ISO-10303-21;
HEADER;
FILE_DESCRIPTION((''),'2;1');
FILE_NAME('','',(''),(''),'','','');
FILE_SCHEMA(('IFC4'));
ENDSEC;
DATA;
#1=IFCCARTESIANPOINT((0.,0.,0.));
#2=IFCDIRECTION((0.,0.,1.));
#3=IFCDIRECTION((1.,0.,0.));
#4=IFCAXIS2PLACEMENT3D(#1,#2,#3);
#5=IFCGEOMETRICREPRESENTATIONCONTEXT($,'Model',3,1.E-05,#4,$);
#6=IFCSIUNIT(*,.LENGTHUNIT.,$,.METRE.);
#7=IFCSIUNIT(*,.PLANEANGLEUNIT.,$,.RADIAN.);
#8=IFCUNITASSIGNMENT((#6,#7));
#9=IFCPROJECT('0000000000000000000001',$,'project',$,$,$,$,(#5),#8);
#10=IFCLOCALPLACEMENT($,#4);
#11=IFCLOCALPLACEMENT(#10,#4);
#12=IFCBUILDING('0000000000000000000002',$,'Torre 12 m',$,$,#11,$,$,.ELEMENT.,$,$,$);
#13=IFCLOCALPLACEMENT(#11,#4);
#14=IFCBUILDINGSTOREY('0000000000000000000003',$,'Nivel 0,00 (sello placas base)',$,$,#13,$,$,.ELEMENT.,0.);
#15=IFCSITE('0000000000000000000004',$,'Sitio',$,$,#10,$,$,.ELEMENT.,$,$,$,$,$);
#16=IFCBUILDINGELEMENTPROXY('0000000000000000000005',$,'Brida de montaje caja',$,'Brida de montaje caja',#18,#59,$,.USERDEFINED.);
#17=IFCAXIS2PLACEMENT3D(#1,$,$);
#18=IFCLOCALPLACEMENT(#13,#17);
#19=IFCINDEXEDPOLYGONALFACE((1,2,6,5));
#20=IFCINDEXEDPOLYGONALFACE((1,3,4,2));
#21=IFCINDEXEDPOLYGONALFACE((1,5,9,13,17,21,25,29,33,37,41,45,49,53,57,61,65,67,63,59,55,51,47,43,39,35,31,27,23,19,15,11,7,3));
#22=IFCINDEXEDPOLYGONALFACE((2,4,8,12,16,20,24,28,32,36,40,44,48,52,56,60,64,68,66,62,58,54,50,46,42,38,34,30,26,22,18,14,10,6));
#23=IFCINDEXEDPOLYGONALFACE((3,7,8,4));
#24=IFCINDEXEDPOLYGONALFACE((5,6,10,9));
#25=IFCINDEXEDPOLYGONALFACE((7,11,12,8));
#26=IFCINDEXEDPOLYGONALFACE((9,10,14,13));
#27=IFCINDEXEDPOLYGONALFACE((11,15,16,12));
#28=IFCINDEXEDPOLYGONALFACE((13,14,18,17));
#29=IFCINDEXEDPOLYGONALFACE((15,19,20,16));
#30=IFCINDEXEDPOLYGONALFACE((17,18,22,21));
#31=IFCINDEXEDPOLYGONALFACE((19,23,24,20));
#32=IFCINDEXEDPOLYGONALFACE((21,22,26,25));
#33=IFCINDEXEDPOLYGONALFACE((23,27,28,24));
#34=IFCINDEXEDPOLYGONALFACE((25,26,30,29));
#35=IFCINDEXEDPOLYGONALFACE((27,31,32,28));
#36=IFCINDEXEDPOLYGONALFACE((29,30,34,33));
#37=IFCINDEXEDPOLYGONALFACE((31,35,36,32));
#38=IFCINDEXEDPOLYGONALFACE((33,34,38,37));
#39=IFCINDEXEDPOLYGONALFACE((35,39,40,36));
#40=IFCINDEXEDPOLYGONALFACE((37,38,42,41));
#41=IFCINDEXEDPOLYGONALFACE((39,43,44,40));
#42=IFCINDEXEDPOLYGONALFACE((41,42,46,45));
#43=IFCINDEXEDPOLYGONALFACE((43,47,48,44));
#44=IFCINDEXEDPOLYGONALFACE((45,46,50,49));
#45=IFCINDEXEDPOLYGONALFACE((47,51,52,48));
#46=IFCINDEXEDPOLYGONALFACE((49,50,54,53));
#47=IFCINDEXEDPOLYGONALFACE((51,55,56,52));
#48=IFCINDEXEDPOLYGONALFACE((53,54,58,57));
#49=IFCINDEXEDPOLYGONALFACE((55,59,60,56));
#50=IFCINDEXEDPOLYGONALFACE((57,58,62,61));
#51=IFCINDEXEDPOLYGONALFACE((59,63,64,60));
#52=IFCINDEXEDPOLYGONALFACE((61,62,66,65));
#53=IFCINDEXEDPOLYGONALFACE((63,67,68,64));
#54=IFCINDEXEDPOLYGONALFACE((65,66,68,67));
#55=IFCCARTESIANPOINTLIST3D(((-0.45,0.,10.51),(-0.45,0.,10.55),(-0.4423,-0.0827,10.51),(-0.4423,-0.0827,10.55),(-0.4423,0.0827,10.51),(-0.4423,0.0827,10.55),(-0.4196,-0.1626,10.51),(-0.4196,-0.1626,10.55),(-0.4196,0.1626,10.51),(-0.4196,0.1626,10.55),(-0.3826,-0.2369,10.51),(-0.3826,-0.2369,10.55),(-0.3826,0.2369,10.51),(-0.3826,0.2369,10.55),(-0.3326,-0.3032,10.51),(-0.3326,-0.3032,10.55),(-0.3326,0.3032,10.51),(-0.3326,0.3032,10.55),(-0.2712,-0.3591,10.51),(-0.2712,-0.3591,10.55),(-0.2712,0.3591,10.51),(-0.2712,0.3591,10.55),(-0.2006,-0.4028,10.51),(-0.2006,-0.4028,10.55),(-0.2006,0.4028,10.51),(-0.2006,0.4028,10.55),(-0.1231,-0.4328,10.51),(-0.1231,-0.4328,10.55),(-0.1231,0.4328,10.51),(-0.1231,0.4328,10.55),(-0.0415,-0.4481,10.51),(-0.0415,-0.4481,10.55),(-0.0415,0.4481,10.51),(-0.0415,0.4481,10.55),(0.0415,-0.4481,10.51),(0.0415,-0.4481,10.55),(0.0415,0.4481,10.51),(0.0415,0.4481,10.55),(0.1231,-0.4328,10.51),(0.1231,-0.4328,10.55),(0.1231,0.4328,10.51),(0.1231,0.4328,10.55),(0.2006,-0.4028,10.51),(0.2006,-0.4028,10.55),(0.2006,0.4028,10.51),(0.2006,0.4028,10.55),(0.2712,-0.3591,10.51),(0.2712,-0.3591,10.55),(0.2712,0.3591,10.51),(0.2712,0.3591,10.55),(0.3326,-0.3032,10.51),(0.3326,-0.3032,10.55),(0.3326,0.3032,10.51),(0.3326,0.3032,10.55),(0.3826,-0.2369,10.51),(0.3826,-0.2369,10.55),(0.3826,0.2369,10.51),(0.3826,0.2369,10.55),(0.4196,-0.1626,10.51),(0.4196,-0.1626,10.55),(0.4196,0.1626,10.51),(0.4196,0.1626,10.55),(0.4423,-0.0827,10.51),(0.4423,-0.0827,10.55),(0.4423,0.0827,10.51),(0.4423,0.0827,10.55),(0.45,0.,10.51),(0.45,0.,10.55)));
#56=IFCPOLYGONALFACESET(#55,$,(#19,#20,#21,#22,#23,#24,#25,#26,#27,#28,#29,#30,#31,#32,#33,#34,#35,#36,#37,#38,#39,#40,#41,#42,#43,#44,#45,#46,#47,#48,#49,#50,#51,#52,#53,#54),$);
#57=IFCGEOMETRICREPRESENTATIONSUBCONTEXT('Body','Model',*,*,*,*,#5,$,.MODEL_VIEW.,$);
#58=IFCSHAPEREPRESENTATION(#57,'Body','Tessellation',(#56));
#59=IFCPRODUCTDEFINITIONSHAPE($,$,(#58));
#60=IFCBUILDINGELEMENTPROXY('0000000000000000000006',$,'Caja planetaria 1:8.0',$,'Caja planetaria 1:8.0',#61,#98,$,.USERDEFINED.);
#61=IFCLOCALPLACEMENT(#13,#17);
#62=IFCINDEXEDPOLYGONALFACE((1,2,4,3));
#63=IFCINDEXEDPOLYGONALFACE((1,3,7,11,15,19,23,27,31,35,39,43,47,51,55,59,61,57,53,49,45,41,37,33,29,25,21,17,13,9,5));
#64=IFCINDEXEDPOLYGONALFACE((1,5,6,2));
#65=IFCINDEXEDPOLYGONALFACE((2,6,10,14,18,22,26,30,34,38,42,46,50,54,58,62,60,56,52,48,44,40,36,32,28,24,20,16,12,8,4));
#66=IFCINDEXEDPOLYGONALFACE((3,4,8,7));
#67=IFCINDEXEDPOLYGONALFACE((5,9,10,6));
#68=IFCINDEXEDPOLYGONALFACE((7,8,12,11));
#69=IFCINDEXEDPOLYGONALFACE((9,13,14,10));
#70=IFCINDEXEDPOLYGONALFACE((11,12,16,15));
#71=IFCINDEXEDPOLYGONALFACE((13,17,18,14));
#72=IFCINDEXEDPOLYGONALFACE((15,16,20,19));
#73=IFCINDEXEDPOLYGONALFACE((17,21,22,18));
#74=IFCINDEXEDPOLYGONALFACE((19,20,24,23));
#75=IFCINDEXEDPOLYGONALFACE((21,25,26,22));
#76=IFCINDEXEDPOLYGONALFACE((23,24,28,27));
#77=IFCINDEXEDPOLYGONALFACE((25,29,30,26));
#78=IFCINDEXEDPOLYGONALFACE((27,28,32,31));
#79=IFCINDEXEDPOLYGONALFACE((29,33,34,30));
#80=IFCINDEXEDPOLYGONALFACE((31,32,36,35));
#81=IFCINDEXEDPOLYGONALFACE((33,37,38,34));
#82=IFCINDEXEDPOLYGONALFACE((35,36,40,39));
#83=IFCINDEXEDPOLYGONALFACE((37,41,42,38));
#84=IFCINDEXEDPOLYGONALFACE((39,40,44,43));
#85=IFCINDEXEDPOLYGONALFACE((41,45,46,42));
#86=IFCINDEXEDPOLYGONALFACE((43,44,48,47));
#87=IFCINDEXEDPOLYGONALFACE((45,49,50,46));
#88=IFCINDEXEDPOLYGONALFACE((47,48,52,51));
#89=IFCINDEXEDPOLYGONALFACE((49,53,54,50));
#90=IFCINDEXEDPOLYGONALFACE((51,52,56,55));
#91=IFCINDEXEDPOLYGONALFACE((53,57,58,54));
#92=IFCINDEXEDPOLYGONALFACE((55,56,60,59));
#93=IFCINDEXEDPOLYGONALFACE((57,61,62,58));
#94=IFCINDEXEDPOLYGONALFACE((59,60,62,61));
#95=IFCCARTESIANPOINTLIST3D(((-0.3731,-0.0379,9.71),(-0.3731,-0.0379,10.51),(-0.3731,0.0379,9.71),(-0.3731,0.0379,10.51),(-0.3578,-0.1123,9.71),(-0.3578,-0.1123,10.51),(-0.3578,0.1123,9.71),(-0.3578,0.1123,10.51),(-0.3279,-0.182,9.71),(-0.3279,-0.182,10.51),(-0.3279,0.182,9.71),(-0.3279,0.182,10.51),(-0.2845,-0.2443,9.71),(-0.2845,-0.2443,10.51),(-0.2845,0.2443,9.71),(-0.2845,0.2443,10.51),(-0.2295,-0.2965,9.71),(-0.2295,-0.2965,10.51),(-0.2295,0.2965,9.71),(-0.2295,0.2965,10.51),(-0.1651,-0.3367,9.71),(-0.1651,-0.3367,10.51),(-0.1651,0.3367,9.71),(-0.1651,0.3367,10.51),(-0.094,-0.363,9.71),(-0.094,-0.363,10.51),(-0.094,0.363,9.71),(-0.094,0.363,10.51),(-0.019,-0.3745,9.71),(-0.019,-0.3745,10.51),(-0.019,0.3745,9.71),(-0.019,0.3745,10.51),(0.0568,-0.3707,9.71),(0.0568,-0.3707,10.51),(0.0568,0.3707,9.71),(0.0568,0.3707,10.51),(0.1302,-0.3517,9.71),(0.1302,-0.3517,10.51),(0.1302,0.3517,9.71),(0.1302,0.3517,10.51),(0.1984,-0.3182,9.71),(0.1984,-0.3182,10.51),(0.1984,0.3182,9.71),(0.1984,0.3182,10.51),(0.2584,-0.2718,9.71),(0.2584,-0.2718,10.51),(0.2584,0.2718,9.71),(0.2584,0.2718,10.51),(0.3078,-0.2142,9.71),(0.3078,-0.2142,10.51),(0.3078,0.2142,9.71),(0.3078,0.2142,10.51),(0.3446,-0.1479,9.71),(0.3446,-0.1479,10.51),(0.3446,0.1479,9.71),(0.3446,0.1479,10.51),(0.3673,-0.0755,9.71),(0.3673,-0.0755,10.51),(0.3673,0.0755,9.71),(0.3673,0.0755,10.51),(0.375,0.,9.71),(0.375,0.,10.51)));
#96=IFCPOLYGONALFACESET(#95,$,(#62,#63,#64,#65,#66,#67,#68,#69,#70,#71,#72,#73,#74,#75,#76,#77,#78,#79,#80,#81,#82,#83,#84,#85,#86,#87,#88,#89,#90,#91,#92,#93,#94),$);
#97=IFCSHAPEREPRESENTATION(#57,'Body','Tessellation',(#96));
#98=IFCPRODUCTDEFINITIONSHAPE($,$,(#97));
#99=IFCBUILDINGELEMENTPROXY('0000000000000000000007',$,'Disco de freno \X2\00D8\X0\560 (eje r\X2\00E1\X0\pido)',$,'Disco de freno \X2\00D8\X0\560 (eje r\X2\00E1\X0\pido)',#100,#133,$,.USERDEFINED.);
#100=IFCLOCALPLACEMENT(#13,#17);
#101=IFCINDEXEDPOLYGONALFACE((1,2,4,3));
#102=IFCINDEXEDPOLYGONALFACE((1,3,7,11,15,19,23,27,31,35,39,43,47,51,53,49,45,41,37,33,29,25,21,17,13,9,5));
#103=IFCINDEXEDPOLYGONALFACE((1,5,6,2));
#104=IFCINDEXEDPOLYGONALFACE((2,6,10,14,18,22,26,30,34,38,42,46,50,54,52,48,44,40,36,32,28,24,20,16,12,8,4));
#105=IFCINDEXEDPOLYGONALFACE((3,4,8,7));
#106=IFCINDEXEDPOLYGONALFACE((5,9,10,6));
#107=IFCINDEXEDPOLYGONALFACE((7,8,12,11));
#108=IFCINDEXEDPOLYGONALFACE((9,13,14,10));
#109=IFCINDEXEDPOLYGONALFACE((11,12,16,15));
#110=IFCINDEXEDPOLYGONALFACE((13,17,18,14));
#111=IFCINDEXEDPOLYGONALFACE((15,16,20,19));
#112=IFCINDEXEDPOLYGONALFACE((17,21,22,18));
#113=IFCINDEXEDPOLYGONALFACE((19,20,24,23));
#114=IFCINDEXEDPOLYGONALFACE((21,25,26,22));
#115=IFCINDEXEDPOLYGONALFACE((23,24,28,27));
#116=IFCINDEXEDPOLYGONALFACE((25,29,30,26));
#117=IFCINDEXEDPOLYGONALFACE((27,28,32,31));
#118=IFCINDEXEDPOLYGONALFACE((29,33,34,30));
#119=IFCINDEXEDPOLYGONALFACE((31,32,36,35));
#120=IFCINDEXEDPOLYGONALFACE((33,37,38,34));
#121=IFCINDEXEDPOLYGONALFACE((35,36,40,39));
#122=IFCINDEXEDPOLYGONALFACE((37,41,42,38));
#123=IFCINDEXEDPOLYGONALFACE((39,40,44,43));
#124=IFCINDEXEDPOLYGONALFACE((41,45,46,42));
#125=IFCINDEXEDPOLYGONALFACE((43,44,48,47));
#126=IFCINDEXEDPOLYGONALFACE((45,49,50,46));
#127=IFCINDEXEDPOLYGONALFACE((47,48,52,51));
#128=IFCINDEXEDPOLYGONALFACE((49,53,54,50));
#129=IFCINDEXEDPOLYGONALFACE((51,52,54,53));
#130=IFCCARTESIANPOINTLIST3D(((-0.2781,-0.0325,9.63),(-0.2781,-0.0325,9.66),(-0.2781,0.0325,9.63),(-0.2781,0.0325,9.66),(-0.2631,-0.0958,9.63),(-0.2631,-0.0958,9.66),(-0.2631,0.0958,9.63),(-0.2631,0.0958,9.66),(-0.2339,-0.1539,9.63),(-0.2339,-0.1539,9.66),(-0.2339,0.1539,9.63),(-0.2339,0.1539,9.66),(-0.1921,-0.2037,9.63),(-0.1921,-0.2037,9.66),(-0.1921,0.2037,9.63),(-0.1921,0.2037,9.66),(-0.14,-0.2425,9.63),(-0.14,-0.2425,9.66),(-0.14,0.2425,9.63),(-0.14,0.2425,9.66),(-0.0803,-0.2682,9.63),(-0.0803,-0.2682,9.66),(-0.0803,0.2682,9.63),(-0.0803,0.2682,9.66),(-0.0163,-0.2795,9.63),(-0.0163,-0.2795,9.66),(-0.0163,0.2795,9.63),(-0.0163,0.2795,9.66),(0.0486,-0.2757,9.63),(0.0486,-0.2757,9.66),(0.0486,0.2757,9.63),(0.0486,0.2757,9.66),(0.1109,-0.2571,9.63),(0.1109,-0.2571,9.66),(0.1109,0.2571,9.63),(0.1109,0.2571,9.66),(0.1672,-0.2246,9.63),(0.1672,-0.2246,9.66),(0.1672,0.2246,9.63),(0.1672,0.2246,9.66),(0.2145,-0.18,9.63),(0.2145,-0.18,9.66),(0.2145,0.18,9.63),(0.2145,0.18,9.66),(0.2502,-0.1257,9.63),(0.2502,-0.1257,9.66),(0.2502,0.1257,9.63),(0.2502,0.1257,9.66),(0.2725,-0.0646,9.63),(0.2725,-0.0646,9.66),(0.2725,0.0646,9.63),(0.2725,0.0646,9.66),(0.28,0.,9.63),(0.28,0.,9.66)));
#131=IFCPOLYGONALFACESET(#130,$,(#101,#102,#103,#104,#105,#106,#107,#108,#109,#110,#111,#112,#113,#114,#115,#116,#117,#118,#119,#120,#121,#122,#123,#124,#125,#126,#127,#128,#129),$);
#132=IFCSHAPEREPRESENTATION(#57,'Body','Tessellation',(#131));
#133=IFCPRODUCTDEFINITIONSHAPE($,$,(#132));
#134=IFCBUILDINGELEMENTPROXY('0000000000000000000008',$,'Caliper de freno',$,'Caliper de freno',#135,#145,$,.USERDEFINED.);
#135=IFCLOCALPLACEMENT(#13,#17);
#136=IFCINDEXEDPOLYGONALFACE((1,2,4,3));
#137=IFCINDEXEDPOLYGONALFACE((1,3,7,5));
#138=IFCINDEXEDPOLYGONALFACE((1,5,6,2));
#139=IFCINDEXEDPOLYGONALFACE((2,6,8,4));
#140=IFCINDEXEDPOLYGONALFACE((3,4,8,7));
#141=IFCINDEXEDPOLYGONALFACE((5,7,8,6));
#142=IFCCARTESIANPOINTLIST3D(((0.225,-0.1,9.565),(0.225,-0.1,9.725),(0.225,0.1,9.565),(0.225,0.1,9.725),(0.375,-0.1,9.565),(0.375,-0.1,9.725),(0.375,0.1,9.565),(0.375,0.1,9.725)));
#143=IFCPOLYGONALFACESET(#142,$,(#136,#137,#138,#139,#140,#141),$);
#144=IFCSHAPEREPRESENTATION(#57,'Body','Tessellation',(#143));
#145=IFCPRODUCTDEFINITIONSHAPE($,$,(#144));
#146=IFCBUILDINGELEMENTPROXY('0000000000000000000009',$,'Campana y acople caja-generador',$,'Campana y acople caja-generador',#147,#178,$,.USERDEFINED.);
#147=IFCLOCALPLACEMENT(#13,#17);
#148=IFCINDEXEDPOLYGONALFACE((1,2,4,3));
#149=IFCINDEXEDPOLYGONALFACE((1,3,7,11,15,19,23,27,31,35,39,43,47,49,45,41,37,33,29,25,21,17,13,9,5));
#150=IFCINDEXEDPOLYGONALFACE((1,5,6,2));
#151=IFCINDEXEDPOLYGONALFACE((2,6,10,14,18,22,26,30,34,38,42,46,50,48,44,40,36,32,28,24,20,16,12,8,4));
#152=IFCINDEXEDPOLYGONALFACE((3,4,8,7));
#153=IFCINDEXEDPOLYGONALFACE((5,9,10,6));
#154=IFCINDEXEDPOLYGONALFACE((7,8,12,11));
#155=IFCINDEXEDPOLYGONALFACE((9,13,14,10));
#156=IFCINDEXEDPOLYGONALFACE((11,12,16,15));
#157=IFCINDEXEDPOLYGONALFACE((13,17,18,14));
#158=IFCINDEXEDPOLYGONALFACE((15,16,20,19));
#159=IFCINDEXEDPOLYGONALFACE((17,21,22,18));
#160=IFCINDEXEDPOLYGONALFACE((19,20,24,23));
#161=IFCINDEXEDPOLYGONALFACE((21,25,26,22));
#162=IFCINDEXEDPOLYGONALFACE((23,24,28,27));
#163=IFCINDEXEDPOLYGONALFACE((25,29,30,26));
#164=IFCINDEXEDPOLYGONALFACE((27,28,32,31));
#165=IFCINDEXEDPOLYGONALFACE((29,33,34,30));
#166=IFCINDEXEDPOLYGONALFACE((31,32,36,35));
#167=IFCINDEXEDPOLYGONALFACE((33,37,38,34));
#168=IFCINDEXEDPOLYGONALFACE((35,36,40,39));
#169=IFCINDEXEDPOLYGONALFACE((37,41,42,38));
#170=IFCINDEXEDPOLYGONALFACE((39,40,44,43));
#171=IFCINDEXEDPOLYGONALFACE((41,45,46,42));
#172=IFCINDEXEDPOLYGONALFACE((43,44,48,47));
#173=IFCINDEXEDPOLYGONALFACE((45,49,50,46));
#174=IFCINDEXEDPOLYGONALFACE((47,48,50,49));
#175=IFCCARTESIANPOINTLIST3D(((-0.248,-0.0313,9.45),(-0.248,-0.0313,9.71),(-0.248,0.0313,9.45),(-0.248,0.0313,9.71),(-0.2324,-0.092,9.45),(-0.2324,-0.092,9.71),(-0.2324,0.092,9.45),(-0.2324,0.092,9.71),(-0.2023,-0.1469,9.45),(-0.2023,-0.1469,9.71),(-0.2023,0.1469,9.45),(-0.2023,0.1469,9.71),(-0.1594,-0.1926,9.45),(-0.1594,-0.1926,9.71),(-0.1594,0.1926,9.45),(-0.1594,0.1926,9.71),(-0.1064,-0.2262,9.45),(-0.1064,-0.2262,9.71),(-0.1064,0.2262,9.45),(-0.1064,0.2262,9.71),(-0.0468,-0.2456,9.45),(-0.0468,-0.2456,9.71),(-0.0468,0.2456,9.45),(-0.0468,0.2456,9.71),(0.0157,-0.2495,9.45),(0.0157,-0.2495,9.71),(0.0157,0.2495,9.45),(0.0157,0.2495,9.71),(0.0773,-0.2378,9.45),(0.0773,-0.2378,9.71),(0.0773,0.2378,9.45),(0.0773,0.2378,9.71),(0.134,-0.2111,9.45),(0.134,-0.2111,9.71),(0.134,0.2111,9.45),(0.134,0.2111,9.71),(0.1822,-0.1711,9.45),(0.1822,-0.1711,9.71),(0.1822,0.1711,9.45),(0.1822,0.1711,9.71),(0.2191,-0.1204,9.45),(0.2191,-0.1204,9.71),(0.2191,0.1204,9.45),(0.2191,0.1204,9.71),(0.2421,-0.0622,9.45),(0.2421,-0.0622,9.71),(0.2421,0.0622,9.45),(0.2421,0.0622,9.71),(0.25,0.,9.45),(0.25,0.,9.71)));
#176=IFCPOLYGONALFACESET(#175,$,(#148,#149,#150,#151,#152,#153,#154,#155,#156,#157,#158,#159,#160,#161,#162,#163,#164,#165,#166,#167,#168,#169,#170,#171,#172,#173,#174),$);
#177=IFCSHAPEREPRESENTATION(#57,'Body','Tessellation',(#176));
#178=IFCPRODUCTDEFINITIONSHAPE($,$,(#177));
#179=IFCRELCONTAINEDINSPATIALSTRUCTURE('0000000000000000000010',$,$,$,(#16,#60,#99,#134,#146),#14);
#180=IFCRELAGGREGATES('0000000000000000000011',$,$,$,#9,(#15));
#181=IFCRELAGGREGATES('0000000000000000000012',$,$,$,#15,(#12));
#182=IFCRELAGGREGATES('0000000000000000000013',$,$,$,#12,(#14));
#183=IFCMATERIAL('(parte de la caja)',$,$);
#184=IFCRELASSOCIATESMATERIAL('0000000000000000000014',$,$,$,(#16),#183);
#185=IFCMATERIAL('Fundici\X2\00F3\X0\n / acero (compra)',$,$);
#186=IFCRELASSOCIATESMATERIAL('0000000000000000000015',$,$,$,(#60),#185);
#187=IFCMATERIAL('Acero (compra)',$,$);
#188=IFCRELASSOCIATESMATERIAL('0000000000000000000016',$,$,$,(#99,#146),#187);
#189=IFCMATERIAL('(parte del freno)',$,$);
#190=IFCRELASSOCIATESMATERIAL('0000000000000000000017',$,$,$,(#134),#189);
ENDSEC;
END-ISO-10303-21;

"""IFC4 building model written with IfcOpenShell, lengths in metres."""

from ifc_helpers import new_model, si_unit, frame, origin, origin_with_axes, origin_2d, place, context, subcontext, project, spatial, rectangle, circle, extrude, material, element, save


model = new_model("IFC4")

# Units and contexts
model_context = context("Model", 3, precision=1e-05, world=origin_with_axes())
body_context = subcontext(model_context, "Body", "Model", "MODEL_VIEW")
ifc_project = project(units=[si_unit("LENGTHUNIT", "METRE"), si_unit("PLANEANGLEUNIT", "RADIAN")], contexts=[model_context])

# Site, building, storey
site_placement = place(None, origin_with_axes())
site = spatial("IfcSite", under=ifc_project, at=site_placement, Name="Sitio", CompositionType="ELEMENT")
building_placement = place(site_placement, origin_with_axes())
building = spatial("IfcBuilding", under=site, at=building_placement, Name="Torre 12 m", CompositionType="ELEMENT")
storey_placement = place(building_placement, origin_with_axes())
storey = spatial("IfcBuildingStorey", under=building, at=storey_placement, Name="Nivel 0,00 (sello placas base)", CompositionType="ELEMENT", Elevation=0.0)

# Building element proxies
ifc_material_1 = material(Name="Acero (compra)")
ifc_material_2 = material(Name="(parte de la caja)")
proxy_1_placement = place(storey_placement, frame((0.0, 0.0, 10.51), z_axis=(0.0, 0.0, 1.0), x_axis=(1.0, 0.0, 0.0)))
element("IfcBuildingElementProxy", 1, at=proxy_1_placement, inside=storey, material=ifc_material_2, Name="Brida de montaje caja", ObjectType="Brida de montaje caja", PredefinedType="USERDEFINED", context=body_context, shape_type="SweptSolid", body=[
    extrude(circle(Radius=0.45, at=origin_2d()), origin(), (0.0, 0.0, 1.0), 0.04),
])
ifc_material_3 = material(Name="Fundición / acero (compra)")
proxy_2_placement = place(storey_placement, frame((0.0, 0.0, 9.71), z_axis=(0.0, 0.0, 1.0), x_axis=(1.0, 0.0, 0.0)))
element("IfcBuildingElementProxy", 2, at=proxy_2_placement, inside=storey, material=ifc_material_3, Name="Caja planetaria 1:8.0", ObjectType="Caja planetaria 1:8.0", PredefinedType="USERDEFINED", context=body_context, shape_type="SweptSolid", body=[
    extrude(circle(Radius=0.375, at=origin_2d()), origin(), (0.0, 0.0, 1.0), 0.8),
])
proxy_3_placement = place(storey_placement, frame((0.0, 0.0, 9.63), z_axis=(0.0, 0.0, 1.0), x_axis=(1.0, 0.0, 0.0)))
element("IfcBuildingElementProxy", 3, at=proxy_3_placement, inside=storey, material=ifc_material_1, Name="Disco de freno Ø560 (eje rápido)", ObjectType="Disco de freno Ø560 (eje rápido)", PredefinedType="USERDEFINED", context=body_context, shape_type="SweptSolid", body=[
    extrude(circle(Radius=0.28, at=origin_2d()), origin(), (0.0, 0.0, 1.0), 0.03),
])
ifc_material_4 = material(Name="(parte del freno)")
proxy_4_placement = place(storey_placement, frame((0.3, 0.0, 9.565), z_axis=(0.0, 0.0, 1.0), x_axis=(1.0, 0.0, 0.0)))
element("IfcBuildingElementProxy", 4, at=proxy_4_placement, inside=storey, material=ifc_material_4, Name="Caliper de freno", ObjectType="Caliper de freno", PredefinedType="USERDEFINED", context=body_context, shape_type="SweptSolid", body=[
    extrude(rectangle(XDim=0.15, YDim=0.2, at=origin_2d()), origin(), (0.0, 0.0, 1.0), 0.16),
])
proxy_5_placement = place(storey_placement, frame((0.0, 0.0, 9.45), z_axis=(0.0, 0.0, 1.0), x_axis=(1.0, 0.0, 0.0)))
element("IfcBuildingElementProxy", 5, at=proxy_5_placement, inside=storey, material=ifc_material_1, Name="Campana y acople caja-generador", ObjectType="Campana y acople caja-generador", PredefinedType="USERDEFINED", context=body_context, shape_type="SweptSolid", body=[
    extrude(circle(Radius=0.25, at=origin_2d()), origin(), (0.0, 0.0, 1.0), 0.26),
])

save(model, "model.ifc")
